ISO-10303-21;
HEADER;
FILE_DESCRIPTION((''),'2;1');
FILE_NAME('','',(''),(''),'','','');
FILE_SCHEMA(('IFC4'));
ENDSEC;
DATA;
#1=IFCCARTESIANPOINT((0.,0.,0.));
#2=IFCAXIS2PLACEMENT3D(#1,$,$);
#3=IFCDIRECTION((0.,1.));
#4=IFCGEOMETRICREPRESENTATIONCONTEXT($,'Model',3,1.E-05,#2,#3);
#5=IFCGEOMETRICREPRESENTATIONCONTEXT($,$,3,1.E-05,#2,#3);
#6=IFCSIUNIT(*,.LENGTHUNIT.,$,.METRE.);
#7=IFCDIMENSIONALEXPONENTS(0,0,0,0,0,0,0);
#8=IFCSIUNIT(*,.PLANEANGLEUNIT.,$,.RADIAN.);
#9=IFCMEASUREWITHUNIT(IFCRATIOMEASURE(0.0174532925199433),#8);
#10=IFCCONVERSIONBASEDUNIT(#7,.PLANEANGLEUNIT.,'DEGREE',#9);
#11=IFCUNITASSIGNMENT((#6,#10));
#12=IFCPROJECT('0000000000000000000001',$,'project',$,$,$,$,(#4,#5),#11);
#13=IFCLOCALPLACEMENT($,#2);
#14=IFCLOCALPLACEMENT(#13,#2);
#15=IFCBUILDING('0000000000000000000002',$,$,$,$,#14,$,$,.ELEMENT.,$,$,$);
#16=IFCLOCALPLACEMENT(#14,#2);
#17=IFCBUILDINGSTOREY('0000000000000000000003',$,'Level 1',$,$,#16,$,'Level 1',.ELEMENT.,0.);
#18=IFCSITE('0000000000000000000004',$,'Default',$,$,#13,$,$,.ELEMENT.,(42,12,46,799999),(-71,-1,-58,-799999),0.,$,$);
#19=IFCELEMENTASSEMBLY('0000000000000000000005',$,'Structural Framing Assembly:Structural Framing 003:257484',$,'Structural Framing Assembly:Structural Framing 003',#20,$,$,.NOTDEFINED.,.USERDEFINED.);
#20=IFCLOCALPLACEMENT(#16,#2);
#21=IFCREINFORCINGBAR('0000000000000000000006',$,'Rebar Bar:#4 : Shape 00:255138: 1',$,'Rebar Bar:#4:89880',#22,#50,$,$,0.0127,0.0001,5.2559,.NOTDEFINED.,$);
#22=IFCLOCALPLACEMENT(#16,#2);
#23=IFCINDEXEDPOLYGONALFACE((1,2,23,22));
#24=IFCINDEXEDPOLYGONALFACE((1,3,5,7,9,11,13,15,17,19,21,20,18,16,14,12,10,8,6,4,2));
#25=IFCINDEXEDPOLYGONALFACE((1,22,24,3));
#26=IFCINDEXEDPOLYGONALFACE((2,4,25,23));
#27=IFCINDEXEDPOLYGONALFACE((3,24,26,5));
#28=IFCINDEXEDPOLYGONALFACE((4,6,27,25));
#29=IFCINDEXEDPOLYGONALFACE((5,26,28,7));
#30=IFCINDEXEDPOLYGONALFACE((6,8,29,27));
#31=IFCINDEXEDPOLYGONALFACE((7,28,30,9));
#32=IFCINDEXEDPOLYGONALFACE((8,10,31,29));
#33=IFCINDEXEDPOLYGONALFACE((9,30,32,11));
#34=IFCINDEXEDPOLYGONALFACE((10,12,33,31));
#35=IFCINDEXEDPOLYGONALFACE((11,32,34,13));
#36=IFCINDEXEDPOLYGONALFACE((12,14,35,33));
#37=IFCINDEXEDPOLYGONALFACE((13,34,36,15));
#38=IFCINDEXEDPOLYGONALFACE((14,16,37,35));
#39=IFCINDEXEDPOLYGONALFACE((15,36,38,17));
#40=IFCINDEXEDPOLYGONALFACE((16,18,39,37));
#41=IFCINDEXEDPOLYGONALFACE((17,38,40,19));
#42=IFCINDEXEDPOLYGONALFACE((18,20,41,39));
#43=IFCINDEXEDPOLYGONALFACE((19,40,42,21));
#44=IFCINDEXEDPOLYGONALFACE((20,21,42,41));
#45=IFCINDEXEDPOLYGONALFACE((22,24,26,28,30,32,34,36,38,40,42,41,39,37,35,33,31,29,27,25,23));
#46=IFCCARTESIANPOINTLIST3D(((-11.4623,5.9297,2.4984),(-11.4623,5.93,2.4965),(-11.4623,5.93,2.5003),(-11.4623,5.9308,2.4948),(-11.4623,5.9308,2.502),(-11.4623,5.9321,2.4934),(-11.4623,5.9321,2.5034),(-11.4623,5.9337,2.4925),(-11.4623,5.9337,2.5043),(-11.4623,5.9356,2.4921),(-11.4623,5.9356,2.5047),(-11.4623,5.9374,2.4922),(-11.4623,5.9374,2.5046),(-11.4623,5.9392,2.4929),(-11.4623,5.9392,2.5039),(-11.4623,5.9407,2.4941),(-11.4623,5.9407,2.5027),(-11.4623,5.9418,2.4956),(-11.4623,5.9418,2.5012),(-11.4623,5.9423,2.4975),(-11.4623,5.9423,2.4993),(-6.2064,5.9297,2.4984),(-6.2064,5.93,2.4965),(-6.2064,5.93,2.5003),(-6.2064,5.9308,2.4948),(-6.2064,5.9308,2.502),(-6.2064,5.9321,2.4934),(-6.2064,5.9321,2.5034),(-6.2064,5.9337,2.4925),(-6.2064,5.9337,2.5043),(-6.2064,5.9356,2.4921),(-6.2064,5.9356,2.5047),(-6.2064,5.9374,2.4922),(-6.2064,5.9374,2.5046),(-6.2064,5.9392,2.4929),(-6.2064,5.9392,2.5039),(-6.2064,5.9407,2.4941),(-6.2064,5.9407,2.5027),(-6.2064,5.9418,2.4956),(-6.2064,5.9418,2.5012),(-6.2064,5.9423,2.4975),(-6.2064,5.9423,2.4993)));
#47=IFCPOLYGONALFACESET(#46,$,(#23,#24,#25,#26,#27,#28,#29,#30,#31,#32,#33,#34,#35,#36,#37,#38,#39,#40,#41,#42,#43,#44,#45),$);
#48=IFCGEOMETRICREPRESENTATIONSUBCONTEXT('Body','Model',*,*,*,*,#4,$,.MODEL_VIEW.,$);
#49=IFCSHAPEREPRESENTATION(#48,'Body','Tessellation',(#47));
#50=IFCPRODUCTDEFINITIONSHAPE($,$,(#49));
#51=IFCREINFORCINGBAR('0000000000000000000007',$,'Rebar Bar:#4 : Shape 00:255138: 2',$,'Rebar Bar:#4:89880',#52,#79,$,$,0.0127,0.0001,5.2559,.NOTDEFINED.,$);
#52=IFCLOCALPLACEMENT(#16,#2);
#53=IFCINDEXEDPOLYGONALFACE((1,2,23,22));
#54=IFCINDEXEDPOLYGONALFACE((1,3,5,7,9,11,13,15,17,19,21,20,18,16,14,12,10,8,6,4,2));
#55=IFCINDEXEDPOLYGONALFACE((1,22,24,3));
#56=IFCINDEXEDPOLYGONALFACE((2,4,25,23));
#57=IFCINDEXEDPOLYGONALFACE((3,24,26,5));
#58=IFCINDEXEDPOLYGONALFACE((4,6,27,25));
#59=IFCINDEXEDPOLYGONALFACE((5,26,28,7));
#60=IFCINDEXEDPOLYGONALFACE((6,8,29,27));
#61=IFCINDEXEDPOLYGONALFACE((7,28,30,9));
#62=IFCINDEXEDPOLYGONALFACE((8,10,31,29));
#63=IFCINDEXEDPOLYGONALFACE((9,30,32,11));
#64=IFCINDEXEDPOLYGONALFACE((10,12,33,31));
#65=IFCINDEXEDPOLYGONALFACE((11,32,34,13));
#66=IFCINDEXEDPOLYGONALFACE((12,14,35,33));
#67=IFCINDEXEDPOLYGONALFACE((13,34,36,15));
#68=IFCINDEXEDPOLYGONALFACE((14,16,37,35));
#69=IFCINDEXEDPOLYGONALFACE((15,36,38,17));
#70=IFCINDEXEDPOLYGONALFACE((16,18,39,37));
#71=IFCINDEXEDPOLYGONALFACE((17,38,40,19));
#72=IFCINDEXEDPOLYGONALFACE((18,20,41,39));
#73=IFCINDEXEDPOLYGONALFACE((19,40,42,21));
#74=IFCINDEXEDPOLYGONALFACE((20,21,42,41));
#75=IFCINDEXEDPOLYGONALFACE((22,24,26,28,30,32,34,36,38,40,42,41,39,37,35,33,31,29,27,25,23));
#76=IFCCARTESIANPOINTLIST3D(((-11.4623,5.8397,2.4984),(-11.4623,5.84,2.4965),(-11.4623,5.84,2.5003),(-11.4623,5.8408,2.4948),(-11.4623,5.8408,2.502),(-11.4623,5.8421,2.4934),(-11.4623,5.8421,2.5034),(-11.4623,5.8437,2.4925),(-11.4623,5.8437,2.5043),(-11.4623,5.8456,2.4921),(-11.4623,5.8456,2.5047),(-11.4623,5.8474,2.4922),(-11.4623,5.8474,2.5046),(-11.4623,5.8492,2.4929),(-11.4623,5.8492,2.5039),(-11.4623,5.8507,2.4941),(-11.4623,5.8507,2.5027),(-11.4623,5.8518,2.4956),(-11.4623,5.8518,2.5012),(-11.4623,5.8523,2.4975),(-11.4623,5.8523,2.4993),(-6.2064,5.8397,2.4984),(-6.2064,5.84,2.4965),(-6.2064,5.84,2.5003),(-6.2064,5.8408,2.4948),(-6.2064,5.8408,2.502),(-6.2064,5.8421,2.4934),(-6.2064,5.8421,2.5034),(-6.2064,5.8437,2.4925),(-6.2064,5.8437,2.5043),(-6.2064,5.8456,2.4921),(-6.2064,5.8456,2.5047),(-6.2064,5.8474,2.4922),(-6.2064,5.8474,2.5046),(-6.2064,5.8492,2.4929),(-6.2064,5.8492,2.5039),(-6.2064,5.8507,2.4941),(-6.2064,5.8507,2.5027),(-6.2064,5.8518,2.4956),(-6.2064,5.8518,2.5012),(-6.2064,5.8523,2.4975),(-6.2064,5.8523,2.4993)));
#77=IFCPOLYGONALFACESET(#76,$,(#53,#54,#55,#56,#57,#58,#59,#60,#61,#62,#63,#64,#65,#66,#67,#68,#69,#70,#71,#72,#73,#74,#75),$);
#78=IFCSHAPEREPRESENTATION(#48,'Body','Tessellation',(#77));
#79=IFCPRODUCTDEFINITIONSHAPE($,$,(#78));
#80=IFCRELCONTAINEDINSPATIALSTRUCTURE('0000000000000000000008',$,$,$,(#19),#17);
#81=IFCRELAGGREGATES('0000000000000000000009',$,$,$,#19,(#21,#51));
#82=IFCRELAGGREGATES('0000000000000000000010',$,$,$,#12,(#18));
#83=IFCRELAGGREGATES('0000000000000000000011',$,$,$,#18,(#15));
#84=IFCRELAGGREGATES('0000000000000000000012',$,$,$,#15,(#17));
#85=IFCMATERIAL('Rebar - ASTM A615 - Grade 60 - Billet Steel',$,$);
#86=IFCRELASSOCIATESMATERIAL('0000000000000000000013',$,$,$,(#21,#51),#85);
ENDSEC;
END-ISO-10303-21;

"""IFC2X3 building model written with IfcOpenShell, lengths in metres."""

from ifc_helpers import new_model, entity, si_unit, converted_unit, direction, origin, place, context, subcontext, project, spatial, material, element, aggregate, save


model = new_model("IFC2X3")

# Units and contexts
model_context = context("Model", 3, precision=1e-05, world=origin(), true_north=direction((0.0, 1.0)))
context_of_model = context(None, 3, precision=1e-05, world=origin(), true_north=direction((0.0, 1.0)))
body_context = subcontext(model_context, "Body", "Model", "MODEL_VIEW")
ifc_project = project(units=[si_unit("LENGTHUNIT", "METRE"), converted_unit("PLANEANGLEUNIT", "DEGREE", entity("IfcRatioMeasure", 0.0174532925199433), si_unit("PLANEANGLEUNIT", "RADIAN"), dimensions=[0, 0, 0, 0, 0, 0, 0])], contexts=[model_context, context_of_model])

# Site, building, storey
site_placement = place(None, origin())
site = spatial("IfcSite", under=ifc_project, at=site_placement, Name="Default", CompositionType="ELEMENT", RefLatitude=(42, 12, 46, 799999), RefLongitude=(-71, -1, -58, -799999), RefElevation=0.0)
building_placement = place(site_placement, origin())
building = spatial("IfcBuilding", under=site, at=building_placement, CompositionType="ELEMENT")
storey_placement = place(building_placement, origin())
storey = spatial("IfcBuildingStorey", under=building, at=storey_placement, Name="Level 1", LongName="Level 1", CompositionType="ELEMENT", Elevation=0.0)

# Element assembly, reinforcing bars
ifc_material_1 = material(Name="Rebar - ASTM A615 - Grade 60 - Billet Steel")
assembly_1_placement = place(storey_placement, origin())
assembly_1 = element("IfcElementAssembly", 1, at=assembly_1_placement, inside=storey, Name="Structural Framing Assembly:Structural Framing 003:257484", ObjectType="Structural Framing Assembly:Structural Framing 003", AssemblyPlace="NOTDEFINED", PredefinedType="USERDEFINED")
reinforcing_bar_1_placement = place(assembly_1_placement, origin())
reinforcing_bar_1 = element("IfcReinforcingBar", 2, at=reinforcing_bar_1_placement, material=ifc_material_1, Name="Rebar Bar:#4 : Shape 00:255138: 1", ObjectType="Rebar Bar:#4:89880", BarLength=5.2559, BarRole="NOTDEFINED", CrossSectionArea=0.0001, NominalDiameter=0.0127, context=body_context, shape_type="AdvancedSweptSolid", body=[
    entity("IfcSweptDiskSolid", entity("IfcCompositeCurve", [entity("IfcCompositeCurveSegment", "CONTINUOUS", True, entity("IfcPolyline", [entity("IfcCartesianPoint", [-6.2064, 5.936, 2.4984]), entity("IfcCartesianPoint", [-11.4623, 5.936, 2.4984])]))], False), 0.0063, None, 0.0, 1.0),
])
reinforcing_bar_2_placement = place(assembly_1_placement, origin())
reinforcing_bar_2 = element("IfcReinforcingBar", 3, at=reinforcing_bar_2_placement, material=ifc_material_1, Name="Rebar Bar:#4 : Shape 00:255138: 2", ObjectType="Rebar Bar:#4:89880", BarLength=5.2559, BarRole="NOTDEFINED", CrossSectionArea=0.0001, NominalDiameter=0.0127, context=body_context, shape_type="AdvancedSweptSolid", body=[
    entity("IfcSweptDiskSolid", entity("IfcCompositeCurve", [entity("IfcCompositeCurveSegment", "CONTINUOUS", True, entity("IfcPolyline", [entity("IfcCartesianPoint", [-6.2064, 5.846, 2.4984]), entity("IfcCartesianPoint", [-11.4623, 5.846, 2.4984])]))], False), 0.0063, None, 0.0, 1.0),
])
aggregate(assembly_1, [reinforcing_bar_1, reinforcing_bar_2])

save(model, "model.ifc")
